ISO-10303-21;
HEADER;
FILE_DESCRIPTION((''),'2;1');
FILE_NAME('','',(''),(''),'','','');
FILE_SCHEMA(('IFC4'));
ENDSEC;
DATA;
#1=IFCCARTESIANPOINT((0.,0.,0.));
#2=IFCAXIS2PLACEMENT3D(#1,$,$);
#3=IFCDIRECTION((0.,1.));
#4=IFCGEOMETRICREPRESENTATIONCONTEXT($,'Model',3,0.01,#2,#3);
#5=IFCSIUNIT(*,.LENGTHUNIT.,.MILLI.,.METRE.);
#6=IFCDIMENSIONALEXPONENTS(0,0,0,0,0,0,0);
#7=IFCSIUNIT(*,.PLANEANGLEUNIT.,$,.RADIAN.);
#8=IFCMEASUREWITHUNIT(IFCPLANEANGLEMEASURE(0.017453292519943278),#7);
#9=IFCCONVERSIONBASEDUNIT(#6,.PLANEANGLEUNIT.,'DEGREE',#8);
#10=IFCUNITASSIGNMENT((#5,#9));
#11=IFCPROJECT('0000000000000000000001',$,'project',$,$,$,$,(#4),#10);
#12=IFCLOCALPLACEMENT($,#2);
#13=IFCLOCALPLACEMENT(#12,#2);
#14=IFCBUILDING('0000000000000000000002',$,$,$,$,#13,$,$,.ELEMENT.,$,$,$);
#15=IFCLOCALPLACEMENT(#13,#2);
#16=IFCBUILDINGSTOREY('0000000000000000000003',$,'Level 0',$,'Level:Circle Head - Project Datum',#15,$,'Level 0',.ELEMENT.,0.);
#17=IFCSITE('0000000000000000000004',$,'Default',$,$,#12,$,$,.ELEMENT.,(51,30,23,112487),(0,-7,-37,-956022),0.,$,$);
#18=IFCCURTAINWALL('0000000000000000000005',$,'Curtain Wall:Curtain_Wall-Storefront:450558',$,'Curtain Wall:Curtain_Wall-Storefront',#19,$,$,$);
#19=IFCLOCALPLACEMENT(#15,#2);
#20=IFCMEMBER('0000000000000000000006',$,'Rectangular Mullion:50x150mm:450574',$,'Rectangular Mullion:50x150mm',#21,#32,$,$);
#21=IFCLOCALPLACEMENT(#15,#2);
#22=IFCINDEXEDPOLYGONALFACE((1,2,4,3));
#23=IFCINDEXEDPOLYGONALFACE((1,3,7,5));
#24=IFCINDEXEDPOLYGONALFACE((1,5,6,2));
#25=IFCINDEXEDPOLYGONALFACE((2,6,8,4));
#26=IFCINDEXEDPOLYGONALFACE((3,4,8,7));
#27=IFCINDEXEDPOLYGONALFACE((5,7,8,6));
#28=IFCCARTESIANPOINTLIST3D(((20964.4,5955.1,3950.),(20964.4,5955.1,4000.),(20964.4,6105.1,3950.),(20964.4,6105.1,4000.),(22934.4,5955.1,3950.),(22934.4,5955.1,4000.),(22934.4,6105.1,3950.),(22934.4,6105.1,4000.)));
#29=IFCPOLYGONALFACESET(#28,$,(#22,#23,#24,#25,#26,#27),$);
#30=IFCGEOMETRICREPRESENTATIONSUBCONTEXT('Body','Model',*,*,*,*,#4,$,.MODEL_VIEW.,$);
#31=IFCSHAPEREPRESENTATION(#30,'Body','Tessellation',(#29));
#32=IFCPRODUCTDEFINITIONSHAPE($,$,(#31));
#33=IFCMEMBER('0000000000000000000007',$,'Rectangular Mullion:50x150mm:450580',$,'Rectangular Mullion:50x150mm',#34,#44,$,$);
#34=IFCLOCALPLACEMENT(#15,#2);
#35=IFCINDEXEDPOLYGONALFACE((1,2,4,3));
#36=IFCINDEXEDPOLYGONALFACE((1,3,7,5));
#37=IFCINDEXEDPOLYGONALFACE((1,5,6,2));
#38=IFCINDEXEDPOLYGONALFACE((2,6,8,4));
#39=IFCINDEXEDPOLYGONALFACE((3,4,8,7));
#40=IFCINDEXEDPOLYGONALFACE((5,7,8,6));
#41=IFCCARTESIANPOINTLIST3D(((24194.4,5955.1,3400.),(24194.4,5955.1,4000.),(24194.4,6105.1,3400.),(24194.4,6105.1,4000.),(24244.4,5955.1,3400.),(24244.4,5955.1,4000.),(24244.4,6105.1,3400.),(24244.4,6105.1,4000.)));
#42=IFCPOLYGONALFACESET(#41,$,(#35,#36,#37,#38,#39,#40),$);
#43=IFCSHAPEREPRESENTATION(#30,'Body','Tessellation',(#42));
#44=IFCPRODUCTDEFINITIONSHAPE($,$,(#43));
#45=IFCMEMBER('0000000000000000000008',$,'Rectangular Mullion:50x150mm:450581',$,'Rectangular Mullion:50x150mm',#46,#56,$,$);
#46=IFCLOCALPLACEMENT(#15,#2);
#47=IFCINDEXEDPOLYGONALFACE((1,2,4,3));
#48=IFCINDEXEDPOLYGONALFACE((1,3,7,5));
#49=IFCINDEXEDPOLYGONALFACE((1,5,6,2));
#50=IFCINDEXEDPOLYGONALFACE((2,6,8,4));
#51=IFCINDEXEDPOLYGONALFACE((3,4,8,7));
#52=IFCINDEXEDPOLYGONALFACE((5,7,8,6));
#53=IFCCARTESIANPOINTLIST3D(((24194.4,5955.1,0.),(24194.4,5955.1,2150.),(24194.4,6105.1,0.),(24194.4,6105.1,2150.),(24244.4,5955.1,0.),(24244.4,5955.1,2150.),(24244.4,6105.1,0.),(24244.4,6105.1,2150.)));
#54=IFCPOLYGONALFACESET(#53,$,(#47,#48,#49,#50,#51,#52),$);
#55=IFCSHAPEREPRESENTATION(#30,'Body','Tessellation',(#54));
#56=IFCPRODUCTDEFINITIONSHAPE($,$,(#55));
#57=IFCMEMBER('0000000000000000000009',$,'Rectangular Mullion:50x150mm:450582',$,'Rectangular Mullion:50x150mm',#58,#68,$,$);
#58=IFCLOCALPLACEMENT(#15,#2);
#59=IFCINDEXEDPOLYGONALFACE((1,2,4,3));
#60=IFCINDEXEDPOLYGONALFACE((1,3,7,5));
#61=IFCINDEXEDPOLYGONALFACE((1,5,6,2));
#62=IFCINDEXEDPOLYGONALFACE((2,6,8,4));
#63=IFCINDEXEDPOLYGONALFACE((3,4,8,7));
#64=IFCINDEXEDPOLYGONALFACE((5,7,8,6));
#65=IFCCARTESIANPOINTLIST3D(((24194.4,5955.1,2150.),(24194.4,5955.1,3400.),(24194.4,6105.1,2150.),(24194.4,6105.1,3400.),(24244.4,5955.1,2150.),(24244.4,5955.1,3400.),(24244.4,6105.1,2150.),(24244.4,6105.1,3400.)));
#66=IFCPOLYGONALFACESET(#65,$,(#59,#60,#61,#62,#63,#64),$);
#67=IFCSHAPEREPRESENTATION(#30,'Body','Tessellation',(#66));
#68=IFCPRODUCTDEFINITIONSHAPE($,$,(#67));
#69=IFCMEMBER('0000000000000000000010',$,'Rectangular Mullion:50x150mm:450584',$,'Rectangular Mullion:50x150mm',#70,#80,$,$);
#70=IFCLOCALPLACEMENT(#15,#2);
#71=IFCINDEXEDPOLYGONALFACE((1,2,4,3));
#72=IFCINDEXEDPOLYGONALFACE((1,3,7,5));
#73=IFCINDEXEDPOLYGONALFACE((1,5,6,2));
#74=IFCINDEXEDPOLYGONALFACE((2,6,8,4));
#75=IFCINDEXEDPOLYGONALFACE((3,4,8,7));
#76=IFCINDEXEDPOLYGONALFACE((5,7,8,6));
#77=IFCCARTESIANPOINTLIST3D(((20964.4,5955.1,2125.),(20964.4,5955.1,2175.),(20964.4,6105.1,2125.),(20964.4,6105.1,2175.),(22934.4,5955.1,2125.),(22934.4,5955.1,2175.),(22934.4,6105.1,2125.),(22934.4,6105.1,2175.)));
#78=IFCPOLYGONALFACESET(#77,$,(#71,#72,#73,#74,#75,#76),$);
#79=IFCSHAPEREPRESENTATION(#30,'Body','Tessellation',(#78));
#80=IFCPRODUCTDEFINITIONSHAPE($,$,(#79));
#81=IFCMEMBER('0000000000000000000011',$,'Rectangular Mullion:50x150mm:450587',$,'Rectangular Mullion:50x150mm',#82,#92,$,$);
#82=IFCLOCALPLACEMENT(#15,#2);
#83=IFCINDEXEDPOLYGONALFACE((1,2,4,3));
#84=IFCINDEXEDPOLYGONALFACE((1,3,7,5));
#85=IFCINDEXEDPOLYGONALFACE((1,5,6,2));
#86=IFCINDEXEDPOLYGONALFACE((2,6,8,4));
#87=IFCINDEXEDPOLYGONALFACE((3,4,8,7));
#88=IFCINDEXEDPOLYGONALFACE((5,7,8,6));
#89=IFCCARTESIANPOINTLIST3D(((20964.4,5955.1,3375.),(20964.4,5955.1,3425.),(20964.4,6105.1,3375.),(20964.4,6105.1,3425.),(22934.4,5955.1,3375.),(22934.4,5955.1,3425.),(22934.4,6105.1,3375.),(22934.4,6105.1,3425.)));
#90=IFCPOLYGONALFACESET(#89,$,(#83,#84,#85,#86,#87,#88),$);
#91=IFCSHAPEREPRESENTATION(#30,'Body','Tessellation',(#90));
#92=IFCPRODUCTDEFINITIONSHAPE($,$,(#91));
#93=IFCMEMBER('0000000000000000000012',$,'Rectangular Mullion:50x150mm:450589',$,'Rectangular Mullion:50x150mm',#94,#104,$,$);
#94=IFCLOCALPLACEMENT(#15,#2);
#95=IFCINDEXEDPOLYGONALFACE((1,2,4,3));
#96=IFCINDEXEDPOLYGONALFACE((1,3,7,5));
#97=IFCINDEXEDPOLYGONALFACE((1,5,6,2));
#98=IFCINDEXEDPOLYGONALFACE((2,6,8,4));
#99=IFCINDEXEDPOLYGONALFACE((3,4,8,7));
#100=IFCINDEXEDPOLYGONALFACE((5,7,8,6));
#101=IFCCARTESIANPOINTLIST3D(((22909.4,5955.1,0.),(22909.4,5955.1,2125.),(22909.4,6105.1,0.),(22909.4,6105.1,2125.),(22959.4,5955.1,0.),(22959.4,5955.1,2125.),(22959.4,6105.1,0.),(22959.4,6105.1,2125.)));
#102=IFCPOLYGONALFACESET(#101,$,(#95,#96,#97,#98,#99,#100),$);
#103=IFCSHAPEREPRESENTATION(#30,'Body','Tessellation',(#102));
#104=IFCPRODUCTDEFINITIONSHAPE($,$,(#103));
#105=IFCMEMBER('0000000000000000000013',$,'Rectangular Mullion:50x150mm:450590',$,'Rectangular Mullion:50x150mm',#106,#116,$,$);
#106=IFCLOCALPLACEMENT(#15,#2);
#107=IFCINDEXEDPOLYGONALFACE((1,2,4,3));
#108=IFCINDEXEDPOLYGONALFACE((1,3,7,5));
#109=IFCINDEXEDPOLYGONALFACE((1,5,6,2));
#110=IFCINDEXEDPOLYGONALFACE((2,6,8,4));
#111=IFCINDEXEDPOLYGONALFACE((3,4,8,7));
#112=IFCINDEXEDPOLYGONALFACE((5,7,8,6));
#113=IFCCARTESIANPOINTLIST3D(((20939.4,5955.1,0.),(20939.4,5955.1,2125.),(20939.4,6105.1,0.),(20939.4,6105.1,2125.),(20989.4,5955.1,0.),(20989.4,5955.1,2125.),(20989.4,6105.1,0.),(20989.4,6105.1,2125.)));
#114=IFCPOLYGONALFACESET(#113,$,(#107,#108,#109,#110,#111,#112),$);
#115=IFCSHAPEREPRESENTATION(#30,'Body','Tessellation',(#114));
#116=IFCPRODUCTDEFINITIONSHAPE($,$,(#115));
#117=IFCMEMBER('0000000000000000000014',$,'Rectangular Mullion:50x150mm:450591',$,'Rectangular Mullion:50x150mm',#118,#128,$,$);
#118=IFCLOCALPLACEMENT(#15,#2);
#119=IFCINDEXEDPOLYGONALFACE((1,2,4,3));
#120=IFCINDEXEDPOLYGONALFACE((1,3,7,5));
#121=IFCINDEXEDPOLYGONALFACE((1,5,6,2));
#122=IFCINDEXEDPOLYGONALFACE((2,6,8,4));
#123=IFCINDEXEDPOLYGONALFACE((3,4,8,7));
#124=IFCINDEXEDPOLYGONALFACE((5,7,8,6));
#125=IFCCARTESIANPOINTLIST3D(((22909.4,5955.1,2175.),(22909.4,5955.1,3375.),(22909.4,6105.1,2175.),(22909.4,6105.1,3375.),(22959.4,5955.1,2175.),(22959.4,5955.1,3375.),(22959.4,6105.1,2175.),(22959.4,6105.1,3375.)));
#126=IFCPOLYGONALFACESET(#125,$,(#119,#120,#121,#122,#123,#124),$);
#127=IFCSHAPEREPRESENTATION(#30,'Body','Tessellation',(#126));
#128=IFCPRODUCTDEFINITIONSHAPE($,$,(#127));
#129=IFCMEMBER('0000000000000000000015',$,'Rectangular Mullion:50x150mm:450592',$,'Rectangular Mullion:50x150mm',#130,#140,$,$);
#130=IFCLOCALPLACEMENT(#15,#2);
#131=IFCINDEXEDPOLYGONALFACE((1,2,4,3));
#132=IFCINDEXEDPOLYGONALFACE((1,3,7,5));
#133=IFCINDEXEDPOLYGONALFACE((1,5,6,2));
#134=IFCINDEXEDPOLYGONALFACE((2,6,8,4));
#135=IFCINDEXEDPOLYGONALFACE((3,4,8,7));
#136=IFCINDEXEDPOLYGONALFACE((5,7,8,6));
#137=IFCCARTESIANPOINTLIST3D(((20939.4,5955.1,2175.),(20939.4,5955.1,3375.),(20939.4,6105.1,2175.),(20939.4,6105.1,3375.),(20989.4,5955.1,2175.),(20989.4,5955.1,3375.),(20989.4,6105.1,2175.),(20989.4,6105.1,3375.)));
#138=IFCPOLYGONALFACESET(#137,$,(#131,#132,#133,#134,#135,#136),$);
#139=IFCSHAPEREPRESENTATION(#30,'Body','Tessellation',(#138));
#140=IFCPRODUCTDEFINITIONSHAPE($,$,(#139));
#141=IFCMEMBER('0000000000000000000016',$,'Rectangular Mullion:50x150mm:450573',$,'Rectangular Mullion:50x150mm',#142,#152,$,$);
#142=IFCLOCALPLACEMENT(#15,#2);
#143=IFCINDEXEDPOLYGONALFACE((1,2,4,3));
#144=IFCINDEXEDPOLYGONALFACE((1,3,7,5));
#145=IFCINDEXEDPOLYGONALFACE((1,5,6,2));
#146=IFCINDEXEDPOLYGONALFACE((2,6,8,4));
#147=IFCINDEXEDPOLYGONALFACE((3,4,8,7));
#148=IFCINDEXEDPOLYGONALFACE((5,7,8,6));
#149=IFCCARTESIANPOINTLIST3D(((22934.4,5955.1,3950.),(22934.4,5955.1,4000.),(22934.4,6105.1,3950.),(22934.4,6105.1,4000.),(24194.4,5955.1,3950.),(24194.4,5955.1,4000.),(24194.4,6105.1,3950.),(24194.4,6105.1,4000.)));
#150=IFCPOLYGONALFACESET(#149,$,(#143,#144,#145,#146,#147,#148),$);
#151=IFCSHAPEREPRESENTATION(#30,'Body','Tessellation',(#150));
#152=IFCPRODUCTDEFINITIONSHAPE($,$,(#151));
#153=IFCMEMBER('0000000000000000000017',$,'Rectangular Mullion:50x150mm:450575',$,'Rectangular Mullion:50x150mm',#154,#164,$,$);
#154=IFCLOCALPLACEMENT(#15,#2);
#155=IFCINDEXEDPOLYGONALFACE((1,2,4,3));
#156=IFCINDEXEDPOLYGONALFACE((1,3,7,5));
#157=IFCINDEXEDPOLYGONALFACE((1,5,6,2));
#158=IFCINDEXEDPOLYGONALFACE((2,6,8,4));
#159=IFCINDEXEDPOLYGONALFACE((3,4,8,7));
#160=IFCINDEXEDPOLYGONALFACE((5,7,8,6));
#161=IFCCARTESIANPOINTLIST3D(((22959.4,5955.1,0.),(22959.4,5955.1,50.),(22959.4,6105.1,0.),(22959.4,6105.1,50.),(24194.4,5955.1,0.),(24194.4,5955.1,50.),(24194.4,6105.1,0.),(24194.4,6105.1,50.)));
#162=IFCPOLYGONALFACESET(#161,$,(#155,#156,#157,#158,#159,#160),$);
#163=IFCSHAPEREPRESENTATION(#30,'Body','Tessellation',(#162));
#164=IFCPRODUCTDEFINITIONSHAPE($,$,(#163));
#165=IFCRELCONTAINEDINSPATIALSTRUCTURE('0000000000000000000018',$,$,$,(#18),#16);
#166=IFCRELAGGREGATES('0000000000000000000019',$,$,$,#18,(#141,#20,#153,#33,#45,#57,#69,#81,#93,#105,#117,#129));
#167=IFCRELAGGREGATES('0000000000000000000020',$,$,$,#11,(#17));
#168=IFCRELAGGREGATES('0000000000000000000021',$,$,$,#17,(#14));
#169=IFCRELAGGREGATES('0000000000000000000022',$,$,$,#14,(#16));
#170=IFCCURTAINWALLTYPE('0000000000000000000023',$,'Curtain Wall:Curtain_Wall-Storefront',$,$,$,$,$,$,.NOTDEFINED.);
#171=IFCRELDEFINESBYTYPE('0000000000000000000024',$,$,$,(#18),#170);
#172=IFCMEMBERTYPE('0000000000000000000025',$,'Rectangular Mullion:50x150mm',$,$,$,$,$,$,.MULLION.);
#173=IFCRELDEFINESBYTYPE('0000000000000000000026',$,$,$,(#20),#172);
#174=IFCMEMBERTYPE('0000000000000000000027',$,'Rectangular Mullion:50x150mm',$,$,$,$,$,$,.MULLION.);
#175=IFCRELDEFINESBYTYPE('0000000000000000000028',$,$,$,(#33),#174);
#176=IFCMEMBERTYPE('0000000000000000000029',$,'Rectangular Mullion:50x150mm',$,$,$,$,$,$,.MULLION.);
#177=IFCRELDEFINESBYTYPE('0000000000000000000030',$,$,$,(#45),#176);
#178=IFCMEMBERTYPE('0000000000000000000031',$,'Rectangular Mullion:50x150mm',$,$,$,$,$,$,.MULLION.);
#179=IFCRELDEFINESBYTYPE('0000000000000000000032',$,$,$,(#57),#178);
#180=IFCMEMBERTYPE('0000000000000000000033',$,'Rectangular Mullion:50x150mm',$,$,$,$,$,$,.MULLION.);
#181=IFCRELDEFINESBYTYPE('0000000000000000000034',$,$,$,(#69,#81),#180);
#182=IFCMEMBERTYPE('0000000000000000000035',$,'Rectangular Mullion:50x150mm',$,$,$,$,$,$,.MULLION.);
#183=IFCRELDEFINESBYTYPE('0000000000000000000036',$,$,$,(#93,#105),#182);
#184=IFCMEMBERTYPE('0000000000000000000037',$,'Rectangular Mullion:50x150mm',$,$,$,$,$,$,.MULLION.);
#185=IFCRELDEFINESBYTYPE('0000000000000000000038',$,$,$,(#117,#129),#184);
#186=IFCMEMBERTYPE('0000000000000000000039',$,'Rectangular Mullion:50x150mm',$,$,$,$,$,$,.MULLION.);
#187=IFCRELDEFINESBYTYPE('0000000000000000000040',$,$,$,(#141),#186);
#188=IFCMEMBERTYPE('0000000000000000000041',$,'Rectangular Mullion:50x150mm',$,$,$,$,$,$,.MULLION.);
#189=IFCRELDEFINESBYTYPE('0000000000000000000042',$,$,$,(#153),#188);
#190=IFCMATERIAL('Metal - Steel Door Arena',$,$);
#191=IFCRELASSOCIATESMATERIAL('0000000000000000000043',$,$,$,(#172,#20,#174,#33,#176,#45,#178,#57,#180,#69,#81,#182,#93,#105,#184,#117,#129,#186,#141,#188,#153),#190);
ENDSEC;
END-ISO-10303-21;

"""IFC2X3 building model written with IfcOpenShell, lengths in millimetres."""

from ifc_helpers import new_model, entity, si_unit, converted_unit, direction, frame, origin, origin_2d_with_axis, place, context, subcontext, project, spatial, rectangle, extrude, source, transform, mapped, material, type_object, type_shapes, element, aggregate, save


model = new_model("IFC2X3")

# Units and contexts
model_context = context("Model", 3, precision=0.01, world=origin(), true_north=direction((0.0, 1.0)))
body_context = subcontext(model_context, "Body", "Model", "MODEL_VIEW")
ifc_project = project(units=[si_unit("LENGTHUNIT", "METRE", prefix="MILLI"), converted_unit("PLANEANGLEUNIT", "DEGREE", entity("IfcPlaneAngleMeasure", 0.017453292519943278), si_unit("PLANEANGLEUNIT", "RADIAN"), dimensions=[0, 0, 0, 0, 0, 0, 0])], contexts=[model_context])

# Site, building, storey
site_placement = place(None, origin())
site = spatial("IfcSite", under=ifc_project, at=site_placement, Name="Default", CompositionType="ELEMENT", RefLatitude=(51, 30, 23, 112487), RefLongitude=(0, -7, -37, -956022), RefElevation=0.0)
building_placement = place(site_placement, origin())
building = spatial("IfcBuilding", under=site, at=building_placement, CompositionType="ELEMENT")
storey_placement = place(building_placement, origin())
storey = spatial("IfcBuildingStorey", under=building, at=storey_placement, Name="Level 0", ObjectType="Level:Circle Head - Project Datum", LongName="Level 0", CompositionType="ELEMENT", Elevation=0.0)

# Curtain wall, members
curtain_wall_type = type_object("IfcCurtainWallType", Name="Curtain Wall:Curtain_Wall-Storefront", PredefinedType="NOTDEFINED")
curtain_wall_placement = place(storey_placement, origin())
curtain_wall = element("IfcCurtainWall", 1, at=curtain_wall_placement, inside=storey, type_object=curtain_wall_type, Name="Curtain Wall:Curtain_Wall-Storefront:450558", ObjectType="Curtain Wall:Curtain_Wall-Storefront")
ifc_material_1 = material(Name="Metal - Steel Door Arena")
member_type_1 = type_object("IfcMemberType", Name="Rectangular Mullion:50x150mm", PredefinedType="MULLION", material=ifc_material_1)
shared_shape_1 = source(origin(), body_context, "Body", "SweptSolid", [
    extrude(rectangle(XDim=50.0, YDim=150.0, at=origin_2d_with_axis()), frame((-25.0, 0.0, -1970.0), z_axis=(0.0, 0.0, 1.0), x_axis=(-1.0, 0.0, 0.0)), (0.0, 0.0, 1.0), 1970.0),
])
type_shapes(member_type_1, [shared_shape_1])
member_1_placement = place(curtain_wall_placement, frame((20964.4, 6030.1, 4000.0), z_axis=(-1.0, 0.0, 0.0), x_axis=(0.0, 0.0, 1.0)))
member_1 = element("IfcMember", 2, at=member_1_placement, type_object=member_type_1, material=ifc_material_1, Name="Rectangular Mullion:50x150mm:450574", ObjectType="Rectangular Mullion:50x150mm", context=body_context, shape_type="MappedRepresentation", body=[
    mapped(shared_shape_1, transform((0.0, 0.0, 0.0), scale=1.0)),
])
member_type_2 = type_object("IfcMemberType", Name="Rectangular Mullion:50x150mm", PredefinedType="MULLION", material=ifc_material_1)
shared_shape_2 = source(origin(), body_context, "Body", "SweptSolid", [
    extrude(rectangle(XDim=50.0, YDim=150.0, at=origin_2d_with_axis()), frame((-25.0, 0.0, -600.0), z_axis=(0.0, 0.0, 1.0), x_axis=(-1.0, 0.0, 0.0)), (0.0, 0.0, 1.0), 600.0),
])
type_shapes(member_type_2, [shared_shape_2])
member_2_placement = place(curtain_wall_placement, frame((24244.4, 6030.1, 4000.0)))
member_2 = element("IfcMember", 3, at=member_2_placement, type_object=member_type_2, material=ifc_material_1, Name="Rectangular Mullion:50x150mm:450580", ObjectType="Rectangular Mullion:50x150mm", context=body_context, shape_type="MappedRepresentation", body=[
    mapped(shared_shape_2, transform((0.0, 0.0, 0.0), scale=1.0)),
])
member_type_3 = type_object("IfcMemberType", Name="Rectangular Mullion:50x150mm", PredefinedType="MULLION", material=ifc_material_1)
shared_shape_3 = source(origin(), body_context, "Body", "SweptSolid", [
    extrude(rectangle(XDim=50.0, YDim=150.0, at=origin_2d_with_axis()), frame((-25.0, 0.0, -2150.0), z_axis=(0.0, 0.0, 1.0), x_axis=(-1.0, 0.0, 0.0)), (0.0, 0.0, 1.0), 2150.0),
])
type_shapes(member_type_3, [shared_shape_3])
member_3_placement = place(curtain_wall_placement, frame((24244.4, 6030.1, 2150.0)))
member_3 = element("IfcMember", 4, at=member_3_placement, type_object=member_type_3, material=ifc_material_1, Name="Rectangular Mullion:50x150mm:450581", ObjectType="Rectangular Mullion:50x150mm", context=body_context, shape_type="MappedRepresentation", body=[
    mapped(shared_shape_3, transform((0.0, 0.0, 0.0), scale=1.0)),
])
member_type_4 = type_object("IfcMemberType", Name="Rectangular Mullion:50x150mm", PredefinedType="MULLION", material=ifc_material_1)
shared_shape_4 = source(origin(), body_context, "Body", "SweptSolid", [
    extrude(rectangle(XDim=50.0, YDim=150.0, at=origin_2d_with_axis()), frame((-25.0, 0.0, -1250.0), z_axis=(0.0, 0.0, 1.0), x_axis=(-1.0, 0.0, 0.0)), (0.0, 0.0, 1.0), 1250.0),
])
type_shapes(member_type_4, [shared_shape_4])
member_4_placement = place(curtain_wall_placement, frame((24244.4, 6030.1, 3400.0)))
member_4 = element("IfcMember", 5, at=member_4_placement, type_object=member_type_4, material=ifc_material_1, Name="Rectangular Mullion:50x150mm:450582", ObjectType="Rectangular Mullion:50x150mm", context=body_context, shape_type="MappedRepresentation", body=[
    mapped(shared_shape_4, transform((0.0, 0.0, 0.0), scale=1.0)),
])
member_type_5 = type_object("IfcMemberType", Name="Rectangular Mullion:50x150mm", PredefinedType="MULLION", material=ifc_material_1)
shared_shape_5 = source(origin(), body_context, "Body", "SweptSolid", [
    extrude(rectangle(XDim=50.0, YDim=150.0, at=origin_2d_with_axis()), frame((0.0, 0.0, -1970.0), z_axis=(0.0, 0.0, 1.0), x_axis=(-1.0, 0.0, 0.0)), (0.0, 0.0, 1.0), 1970.0),
])
type_shapes(member_type_5, [shared_shape_5])
member_5_placement = place(curtain_wall_placement, frame((20964.4, 6030.1, 2150.0), z_axis=(-1.0, 0.0, 0.0), x_axis=(0.0, 0.0, 1.0)))
member_5 = element("IfcMember", 6, at=member_5_placement, type_object=member_type_5, material=ifc_material_1, Name="Rectangular Mullion:50x150mm:450584", ObjectType="Rectangular Mullion:50x150mm", context=body_context, shape_type="MappedRepresentation", body=[
    mapped(shared_shape_5, transform((0.0, 0.0, 0.0), scale=1.0)),
])
member_6_placement = place(curtain_wall_placement, frame((20964.4, 6030.1, 3400.0), z_axis=(-1.0, 0.0, 0.0), x_axis=(0.0, 0.0, 1.0)))
member_6 = element("IfcMember", 7, at=member_6_placement, type_object=member_type_5, material=ifc_material_1, Name="Rectangular Mullion:50x150mm:450587", ObjectType="Rectangular Mullion:50x150mm", context=body_context, shape_type="MappedRepresentation", body=[
    mapped(shared_shape_5, transform((0.0, 0.0, 0.0), scale=1.0)),
])
member_type_6 = type_object("IfcMemberType", Name="Rectangular Mullion:50x150mm", PredefinedType="MULLION", material=ifc_material_1)
shared_shape_6 = source(origin(), body_context, "Body", "SweptSolid", [
    extrude(rectangle(XDim=50.0, YDim=150.0, at=origin_2d_with_axis()), frame((0.0, 0.0, -2125.0), z_axis=(0.0, 0.0, 1.0), x_axis=(-1.0, 0.0, 0.0)), (0.0, 0.0, 1.0), 2125.0),
])
type_shapes(member_type_6, [shared_shape_6])
member_7_placement = place(curtain_wall_placement, frame((22934.4, 6030.1, 0.0), z_axis=(0.0, 0.0, -1.0), x_axis=(-1.0, 0.0, 0.0)))
member_7 = element("IfcMember", 8, at=member_7_placement, type_object=member_type_6, material=ifc_material_1, Name="Rectangular Mullion:50x150mm:450589", ObjectType="Rectangular Mullion:50x150mm", context=body_context, shape_type="MappedRepresentation", body=[
    mapped(shared_shape_6, transform((0.0, 0.0, 0.0), scale=1.0)),
])
member_8_placement = place(curtain_wall_placement, frame((20964.4, 6030.1, 0.0), z_axis=(0.0, 0.0, -1.0), x_axis=(-1.0, 0.0, 0.0)))
member_8 = element("IfcMember", 9, at=member_8_placement, type_object=member_type_6, material=ifc_material_1, Name="Rectangular Mullion:50x150mm:450590", ObjectType="Rectangular Mullion:50x150mm", context=body_context, shape_type="MappedRepresentation", body=[
    mapped(shared_shape_6, transform((0.0, 0.0, 0.0), scale=1.0)),
])
member_type_7 = type_object("IfcMemberType", Name="Rectangular Mullion:50x150mm", PredefinedType="MULLION", material=ifc_material_1)
shared_shape_7 = source(origin(), body_context, "Body", "SweptSolid", [
    extrude(rectangle(XDim=50.0, YDim=150.0, at=origin_2d_with_axis()), frame((0.0, 0.0, -1200.0), z_axis=(0.0, 0.0, 1.0), x_axis=(-1.0, 0.0, 0.0)), (0.0, 0.0, 1.0), 1200.0),
])
type_shapes(member_type_7, [shared_shape_7])
member_9_placement = place(curtain_wall_placement, frame((22934.4, 6030.1, 2175.0), z_axis=(0.0, 0.0, -1.0), x_axis=(-1.0, 0.0, 0.0)))
member_9 = element("IfcMember", 10, at=member_9_placement, type_object=member_type_7, material=ifc_material_1, Name="Rectangular Mullion:50x150mm:450591", ObjectType="Rectangular Mullion:50x150mm", context=body_context, shape_type="MappedRepresentation", body=[
    mapped(shared_shape_7, transform((0.0, 0.0, 0.0), scale=1.0)),
])
member_10_placement = place(curtain_wall_placement, frame((20964.4, 6030.1, 2175.0), z_axis=(0.0, 0.0, -1.0), x_axis=(-1.0, 0.0, 0.0)))
member_10 = element("IfcMember", 11, at=member_10_placement, type_object=member_type_7, material=ifc_material_1, Name="Rectangular Mullion:50x150mm:450592", ObjectType="Rectangular Mullion:50x150mm", context=body_context, shape_type="MappedRepresentation", body=[
    mapped(shared_shape_7, transform((0.0, 0.0, 0.0), scale=1.0)),
])
member_type_8 = type_object("IfcMemberType", Name="Rectangular Mullion:50x150mm", PredefinedType="MULLION", material=ifc_material_1)
shared_shape_8 = source(origin(), body_context, "Body", "SweptSolid", [
    extrude(rectangle(XDim=50.0, YDim=150.0, at=origin_2d_with_axis()), frame((-25.0, 0.0, -1260.0), z_axis=(0.0, 0.0, 1.0), x_axis=(-1.0, 0.0, 0.0)), (0.0, 0.0, 1.0), 1260.0),
])
type_shapes(member_type_8, [shared_shape_8])
member_11_placement = place(curtain_wall_placement, frame((22934.4, 6030.1, 4000.0), z_axis=(-1.0, 0.0, 0.0), x_axis=(0.0, 0.0, 1.0)))
member_11 = element("IfcMember", 12, at=member_11_placement, type_object=member_type_8, material=ifc_material_1, Name="Rectangular Mullion:50x150mm:450573", ObjectType="Rectangular Mullion:50x150mm", context=body_context, shape_type="MappedRepresentation", body=[
    mapped(shared_shape_8, transform((0.0, 0.0, 0.0), scale=1.0)),
])
member_type_9 = type_object("IfcMemberType", Name="Rectangular Mullion:50x150mm", PredefinedType="MULLION", material=ifc_material_1)
shared_shape_9 = source(origin(), body_context, "Body", "SweptSolid", [
    extrude(rectangle(XDim=50.0, YDim=150.0, at=origin_2d_with_axis()), frame((-25.0, 0.0, -1235.0), z_axis=(0.0, 0.0, 1.0), x_axis=(-1.0, 0.0, 0.0)), (0.0, 0.0, 1.0), 1235.0),
])
type_shapes(member_type_9, [shared_shape_9])
member_12_placement = place(curtain_wall_placement, frame((24194.4, 6030.1, 0.0), z_axis=(1.0, 0.0, 0.0), x_axis=(0.0, 0.0, -1.0)))
member_12 = element("IfcMember", 13, at=member_12_placement, type_object=member_type_9, material=ifc_material_1, Name="Rectangular Mullion:50x150mm:450575", ObjectType="Rectangular Mullion:50x150mm", context=body_context, shape_type="MappedRepresentation", body=[
    mapped(shared_shape_9, transform((0.0, 0.0, 0.0), scale=1.0)),
])
aggregate(curtain_wall, [member_11, member_1, member_12, member_2, member_3, member_4, member_5, member_6, member_7, member_8, member_9, member_10])

save(model, "model.ifc")
